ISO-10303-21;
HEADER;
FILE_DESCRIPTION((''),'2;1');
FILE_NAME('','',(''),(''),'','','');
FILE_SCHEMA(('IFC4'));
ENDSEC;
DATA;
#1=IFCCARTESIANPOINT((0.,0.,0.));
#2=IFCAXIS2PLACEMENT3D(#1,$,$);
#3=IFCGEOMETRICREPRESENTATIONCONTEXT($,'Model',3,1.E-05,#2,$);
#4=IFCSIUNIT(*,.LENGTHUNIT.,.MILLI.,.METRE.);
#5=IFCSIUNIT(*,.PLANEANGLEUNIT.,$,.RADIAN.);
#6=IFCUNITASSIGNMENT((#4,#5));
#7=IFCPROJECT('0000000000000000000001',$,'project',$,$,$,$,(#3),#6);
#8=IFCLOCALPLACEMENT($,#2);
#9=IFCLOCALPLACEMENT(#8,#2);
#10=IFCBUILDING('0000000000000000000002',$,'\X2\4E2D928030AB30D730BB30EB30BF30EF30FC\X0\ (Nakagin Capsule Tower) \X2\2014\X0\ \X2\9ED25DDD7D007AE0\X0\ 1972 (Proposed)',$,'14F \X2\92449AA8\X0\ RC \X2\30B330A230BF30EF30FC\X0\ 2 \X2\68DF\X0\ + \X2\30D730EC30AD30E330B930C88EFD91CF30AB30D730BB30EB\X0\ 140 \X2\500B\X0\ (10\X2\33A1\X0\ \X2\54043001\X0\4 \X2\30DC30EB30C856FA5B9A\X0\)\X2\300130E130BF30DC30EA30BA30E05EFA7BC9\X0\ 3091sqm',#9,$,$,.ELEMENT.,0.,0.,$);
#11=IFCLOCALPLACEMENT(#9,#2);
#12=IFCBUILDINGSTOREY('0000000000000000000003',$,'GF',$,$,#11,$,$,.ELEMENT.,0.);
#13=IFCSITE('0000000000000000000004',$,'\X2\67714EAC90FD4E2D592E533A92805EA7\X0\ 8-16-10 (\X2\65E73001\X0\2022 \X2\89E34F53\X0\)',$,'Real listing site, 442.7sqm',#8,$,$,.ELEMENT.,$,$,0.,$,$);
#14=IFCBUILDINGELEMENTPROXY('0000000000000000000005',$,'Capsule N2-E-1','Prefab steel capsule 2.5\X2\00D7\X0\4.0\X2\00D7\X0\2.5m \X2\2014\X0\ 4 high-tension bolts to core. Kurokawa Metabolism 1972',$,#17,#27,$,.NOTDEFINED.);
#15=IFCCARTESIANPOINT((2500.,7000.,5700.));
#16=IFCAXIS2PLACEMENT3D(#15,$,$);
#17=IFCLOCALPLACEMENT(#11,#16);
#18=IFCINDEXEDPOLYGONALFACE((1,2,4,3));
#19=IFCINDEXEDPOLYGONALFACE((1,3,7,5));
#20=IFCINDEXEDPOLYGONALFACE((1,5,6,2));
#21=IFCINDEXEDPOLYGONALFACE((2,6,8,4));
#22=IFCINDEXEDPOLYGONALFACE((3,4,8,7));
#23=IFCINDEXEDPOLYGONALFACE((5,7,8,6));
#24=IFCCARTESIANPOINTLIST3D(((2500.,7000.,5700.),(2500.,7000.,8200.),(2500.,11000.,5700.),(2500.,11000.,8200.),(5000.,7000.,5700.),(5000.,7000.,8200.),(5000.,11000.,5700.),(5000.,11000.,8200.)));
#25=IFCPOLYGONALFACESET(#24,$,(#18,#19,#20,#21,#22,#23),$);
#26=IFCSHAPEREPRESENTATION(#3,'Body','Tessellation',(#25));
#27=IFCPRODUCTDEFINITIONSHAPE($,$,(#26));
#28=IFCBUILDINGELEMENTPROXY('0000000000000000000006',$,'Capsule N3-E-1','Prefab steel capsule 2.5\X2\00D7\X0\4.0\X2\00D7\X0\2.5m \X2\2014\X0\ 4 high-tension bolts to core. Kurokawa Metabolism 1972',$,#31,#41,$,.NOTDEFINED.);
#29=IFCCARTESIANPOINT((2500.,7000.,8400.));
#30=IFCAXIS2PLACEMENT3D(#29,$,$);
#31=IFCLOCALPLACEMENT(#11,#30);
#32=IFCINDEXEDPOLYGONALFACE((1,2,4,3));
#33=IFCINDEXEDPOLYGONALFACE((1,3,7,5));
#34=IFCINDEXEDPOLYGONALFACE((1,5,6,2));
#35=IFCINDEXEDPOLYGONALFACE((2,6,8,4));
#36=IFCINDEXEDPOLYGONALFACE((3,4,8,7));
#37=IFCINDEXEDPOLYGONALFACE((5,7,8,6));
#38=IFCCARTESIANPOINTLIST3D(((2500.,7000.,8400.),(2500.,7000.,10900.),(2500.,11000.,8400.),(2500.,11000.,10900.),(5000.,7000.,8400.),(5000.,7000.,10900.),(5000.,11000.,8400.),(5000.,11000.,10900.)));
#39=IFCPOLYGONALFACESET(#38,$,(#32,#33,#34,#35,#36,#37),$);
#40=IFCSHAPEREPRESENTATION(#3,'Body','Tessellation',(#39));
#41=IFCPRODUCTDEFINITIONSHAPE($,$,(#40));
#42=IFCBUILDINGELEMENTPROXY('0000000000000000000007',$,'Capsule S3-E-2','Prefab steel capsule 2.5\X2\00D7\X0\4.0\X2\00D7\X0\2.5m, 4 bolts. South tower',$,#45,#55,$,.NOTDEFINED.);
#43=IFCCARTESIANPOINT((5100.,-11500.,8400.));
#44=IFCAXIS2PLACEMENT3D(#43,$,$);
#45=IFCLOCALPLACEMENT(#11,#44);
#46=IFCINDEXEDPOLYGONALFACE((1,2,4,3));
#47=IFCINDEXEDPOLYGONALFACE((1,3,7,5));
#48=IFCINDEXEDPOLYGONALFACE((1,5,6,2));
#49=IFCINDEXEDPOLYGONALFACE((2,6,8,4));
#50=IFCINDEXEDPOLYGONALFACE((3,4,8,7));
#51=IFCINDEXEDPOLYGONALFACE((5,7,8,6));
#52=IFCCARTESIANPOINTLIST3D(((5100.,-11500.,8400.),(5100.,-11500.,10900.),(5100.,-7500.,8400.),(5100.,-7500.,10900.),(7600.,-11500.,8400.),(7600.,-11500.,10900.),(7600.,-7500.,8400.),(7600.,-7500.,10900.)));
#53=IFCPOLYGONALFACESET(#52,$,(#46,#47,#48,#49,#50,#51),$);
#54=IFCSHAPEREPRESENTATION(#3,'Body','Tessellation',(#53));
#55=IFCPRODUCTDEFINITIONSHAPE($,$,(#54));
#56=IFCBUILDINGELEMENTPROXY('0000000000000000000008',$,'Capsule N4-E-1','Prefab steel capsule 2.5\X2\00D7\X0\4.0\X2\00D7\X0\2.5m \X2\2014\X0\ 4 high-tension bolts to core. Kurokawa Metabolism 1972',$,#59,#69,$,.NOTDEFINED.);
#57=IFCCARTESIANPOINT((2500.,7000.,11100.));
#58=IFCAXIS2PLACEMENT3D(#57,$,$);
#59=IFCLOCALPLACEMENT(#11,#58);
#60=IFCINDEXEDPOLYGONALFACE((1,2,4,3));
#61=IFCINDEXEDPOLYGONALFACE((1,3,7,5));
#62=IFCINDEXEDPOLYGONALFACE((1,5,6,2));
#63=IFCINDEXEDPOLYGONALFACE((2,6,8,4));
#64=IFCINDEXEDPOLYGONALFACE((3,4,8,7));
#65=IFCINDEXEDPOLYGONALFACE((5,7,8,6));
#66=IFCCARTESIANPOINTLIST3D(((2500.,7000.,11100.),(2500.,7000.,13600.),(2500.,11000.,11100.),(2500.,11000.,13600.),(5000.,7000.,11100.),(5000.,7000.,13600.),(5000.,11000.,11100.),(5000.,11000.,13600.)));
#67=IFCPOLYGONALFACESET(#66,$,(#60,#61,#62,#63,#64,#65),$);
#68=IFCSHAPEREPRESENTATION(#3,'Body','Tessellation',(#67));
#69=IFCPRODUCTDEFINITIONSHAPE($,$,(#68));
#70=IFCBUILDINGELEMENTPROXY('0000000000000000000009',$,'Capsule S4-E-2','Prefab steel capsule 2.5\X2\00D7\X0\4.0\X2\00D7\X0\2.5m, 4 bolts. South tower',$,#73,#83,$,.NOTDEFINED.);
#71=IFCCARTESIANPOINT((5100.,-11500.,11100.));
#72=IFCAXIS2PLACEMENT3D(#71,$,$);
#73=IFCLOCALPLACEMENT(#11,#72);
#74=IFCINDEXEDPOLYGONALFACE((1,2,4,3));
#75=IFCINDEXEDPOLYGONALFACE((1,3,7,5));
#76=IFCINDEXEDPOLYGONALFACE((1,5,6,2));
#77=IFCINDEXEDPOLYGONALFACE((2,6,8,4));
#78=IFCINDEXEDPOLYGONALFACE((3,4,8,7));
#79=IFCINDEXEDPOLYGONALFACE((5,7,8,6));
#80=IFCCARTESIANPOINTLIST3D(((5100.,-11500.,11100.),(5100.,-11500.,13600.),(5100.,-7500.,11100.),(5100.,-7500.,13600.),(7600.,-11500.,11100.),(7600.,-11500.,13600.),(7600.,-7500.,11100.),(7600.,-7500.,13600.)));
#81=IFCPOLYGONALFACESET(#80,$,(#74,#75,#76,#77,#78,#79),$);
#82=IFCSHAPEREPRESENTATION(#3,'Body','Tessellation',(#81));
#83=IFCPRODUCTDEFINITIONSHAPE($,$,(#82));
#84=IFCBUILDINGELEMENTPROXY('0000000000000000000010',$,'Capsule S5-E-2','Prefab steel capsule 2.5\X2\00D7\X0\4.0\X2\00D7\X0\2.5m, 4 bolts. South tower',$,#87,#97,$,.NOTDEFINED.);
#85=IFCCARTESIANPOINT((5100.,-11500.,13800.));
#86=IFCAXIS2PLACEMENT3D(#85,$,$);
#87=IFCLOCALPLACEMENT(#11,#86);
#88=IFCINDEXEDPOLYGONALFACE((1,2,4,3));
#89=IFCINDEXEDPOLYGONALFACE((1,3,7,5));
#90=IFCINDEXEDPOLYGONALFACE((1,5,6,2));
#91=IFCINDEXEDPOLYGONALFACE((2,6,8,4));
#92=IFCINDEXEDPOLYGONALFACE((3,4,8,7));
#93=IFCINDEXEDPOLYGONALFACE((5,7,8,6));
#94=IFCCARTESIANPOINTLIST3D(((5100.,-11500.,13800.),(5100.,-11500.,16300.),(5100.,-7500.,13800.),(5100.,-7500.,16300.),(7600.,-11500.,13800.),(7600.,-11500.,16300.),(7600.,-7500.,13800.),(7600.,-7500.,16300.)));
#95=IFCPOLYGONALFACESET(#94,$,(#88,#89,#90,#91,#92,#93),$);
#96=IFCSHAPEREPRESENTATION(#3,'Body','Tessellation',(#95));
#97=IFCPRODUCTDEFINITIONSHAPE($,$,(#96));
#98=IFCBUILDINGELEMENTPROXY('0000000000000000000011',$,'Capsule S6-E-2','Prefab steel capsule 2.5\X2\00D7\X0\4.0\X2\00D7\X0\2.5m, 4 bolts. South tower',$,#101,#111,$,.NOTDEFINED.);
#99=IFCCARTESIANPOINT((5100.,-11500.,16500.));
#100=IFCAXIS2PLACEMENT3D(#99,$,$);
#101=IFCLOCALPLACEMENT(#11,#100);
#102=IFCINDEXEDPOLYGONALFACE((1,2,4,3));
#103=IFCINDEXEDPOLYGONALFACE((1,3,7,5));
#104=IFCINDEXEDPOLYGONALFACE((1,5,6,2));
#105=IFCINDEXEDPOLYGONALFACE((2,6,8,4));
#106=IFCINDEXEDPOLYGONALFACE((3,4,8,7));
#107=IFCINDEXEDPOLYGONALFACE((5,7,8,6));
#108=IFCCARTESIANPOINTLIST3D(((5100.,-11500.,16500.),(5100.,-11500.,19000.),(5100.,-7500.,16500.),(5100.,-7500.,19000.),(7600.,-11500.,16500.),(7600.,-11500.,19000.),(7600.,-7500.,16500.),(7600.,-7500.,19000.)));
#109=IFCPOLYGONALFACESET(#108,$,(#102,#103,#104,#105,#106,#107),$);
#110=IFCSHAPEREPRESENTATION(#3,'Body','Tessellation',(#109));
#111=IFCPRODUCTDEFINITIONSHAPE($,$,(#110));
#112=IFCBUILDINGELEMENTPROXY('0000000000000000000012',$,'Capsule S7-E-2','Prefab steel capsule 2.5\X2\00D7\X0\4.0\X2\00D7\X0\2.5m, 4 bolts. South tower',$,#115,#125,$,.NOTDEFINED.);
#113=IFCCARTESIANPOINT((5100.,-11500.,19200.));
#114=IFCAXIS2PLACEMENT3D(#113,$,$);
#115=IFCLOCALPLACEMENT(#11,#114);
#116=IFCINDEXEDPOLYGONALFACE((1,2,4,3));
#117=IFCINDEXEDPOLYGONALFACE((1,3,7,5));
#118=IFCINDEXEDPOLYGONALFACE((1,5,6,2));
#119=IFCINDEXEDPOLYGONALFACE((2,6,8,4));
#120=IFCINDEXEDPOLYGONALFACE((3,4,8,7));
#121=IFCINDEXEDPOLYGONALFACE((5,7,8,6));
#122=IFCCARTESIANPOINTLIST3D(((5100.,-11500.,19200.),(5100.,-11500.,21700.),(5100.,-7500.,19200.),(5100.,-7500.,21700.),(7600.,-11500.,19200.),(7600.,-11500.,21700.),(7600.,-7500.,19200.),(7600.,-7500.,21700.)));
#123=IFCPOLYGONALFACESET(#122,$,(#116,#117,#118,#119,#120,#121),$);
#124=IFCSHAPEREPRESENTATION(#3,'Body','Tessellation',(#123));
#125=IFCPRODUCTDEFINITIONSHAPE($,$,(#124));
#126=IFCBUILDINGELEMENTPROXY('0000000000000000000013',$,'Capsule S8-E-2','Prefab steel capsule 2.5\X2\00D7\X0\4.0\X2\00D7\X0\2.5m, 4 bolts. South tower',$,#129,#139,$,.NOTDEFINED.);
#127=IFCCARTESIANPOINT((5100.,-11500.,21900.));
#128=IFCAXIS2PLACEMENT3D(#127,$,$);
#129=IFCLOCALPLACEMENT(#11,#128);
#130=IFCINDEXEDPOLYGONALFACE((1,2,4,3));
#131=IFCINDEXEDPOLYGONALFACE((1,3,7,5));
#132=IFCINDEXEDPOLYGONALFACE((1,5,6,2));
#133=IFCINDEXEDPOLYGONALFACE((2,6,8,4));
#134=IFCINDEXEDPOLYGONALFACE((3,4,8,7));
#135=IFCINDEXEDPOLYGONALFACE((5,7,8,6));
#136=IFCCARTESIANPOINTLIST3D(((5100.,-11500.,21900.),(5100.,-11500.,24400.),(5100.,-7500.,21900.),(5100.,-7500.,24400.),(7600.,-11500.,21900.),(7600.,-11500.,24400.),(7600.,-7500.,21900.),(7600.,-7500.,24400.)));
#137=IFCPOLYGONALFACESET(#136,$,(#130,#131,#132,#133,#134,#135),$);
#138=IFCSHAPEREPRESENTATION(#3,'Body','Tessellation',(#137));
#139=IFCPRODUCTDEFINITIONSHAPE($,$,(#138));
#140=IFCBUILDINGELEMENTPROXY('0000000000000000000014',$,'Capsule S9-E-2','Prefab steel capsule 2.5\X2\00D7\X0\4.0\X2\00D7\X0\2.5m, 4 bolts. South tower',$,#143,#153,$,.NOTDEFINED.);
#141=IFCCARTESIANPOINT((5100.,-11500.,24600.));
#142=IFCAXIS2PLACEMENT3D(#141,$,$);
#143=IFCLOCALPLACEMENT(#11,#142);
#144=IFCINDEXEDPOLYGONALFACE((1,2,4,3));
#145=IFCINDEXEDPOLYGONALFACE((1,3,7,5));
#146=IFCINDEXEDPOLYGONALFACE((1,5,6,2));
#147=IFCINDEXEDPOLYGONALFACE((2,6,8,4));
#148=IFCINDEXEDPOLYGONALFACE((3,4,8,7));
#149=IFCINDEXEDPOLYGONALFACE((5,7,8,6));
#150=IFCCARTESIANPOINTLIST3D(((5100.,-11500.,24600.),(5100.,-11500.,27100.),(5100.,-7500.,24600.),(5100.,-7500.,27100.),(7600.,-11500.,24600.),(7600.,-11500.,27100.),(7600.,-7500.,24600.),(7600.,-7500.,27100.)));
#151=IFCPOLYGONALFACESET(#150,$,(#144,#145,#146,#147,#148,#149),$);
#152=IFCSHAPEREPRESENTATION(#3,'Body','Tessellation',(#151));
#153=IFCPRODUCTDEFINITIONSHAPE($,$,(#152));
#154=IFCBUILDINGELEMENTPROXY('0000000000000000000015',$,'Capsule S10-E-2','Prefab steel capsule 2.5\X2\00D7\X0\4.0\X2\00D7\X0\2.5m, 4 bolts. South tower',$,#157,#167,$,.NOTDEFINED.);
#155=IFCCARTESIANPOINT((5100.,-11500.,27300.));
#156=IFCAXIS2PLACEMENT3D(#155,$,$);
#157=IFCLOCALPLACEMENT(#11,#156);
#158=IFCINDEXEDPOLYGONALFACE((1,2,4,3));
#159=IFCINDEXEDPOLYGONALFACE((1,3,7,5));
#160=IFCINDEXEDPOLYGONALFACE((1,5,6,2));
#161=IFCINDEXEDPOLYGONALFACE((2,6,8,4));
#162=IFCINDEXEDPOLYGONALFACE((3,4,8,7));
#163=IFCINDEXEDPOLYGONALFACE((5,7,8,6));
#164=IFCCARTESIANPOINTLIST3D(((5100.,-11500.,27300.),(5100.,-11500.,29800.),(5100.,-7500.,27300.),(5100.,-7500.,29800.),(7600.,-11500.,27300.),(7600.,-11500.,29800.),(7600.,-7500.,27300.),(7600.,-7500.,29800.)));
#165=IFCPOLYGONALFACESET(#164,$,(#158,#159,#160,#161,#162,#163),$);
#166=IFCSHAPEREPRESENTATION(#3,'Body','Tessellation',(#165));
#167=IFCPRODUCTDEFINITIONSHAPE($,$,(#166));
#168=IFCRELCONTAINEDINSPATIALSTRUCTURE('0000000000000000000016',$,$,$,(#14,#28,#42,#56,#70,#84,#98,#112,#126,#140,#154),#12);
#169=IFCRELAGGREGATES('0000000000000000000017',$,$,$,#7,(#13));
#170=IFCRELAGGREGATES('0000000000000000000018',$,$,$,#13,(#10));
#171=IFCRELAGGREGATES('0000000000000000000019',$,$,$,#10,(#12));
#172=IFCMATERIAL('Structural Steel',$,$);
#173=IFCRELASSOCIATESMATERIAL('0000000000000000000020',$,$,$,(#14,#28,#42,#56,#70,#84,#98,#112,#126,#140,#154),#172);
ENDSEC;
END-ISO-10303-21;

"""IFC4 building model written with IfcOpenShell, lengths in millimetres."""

from ifc_helpers import new_model, si_unit, frame, frame_2d, origin, place, context, project, spatial, rectangle, extrude, material, element, save


model = new_model("IFC4")

# Units and contexts
model_context = context("Model", 3, precision=1e-05, world=origin())
ifc_project = project(units=[si_unit("LENGTHUNIT", "METRE", prefix="MILLI"), si_unit("PLANEANGLEUNIT", "RADIAN")], contexts=[model_context])

# Site, building, storey
site_placement = place(None, origin())
site = spatial("IfcSite", under=ifc_project, at=site_placement, Name="東京都中央区銀座 8-16-10 (旧、2022 解体)", ObjectType="Real listing site, 442.7sqm", CompositionType="ELEMENT", RefElevation=0.0)
building_placement = place(site_placement, origin())
building = spatial("IfcBuilding", under=site, at=building_placement, Name="中銀カプセルタワー (Nakagin Capsule Tower) — 黒川紀章 1972 (Proposed)", ObjectType="14F 鉄骨 RC コアタワー 2 棟 + プレキャスト軽量カプセル 140 個 (10㎡ 各、4 ボルト固定)、メタボリズム建築 3091sqm", CompositionType="ELEMENT", ElevationOfRefHeight=0.0, ElevationOfTerrain=0.0)
storey_placement = place(building_placement, origin())
storey = spatial("IfcBuildingStorey", under=building, at=storey_placement, Name="GF", CompositionType="ELEMENT", Elevation=0.0)

# Shared definitions
ifc_material_1 = material(Name="Structural Steel")

# Building element proxies
proxy_1_placement = place(storey_placement, frame((2500.0, 7000.0, 5700.0)))
element("IfcBuildingElementProxy", 1, at=proxy_1_placement, inside=storey, material=ifc_material_1, Name="Capsule N2-E-1", Description="Prefab steel capsule 2.5×4.0×2.5m — 4 high-tension bolts to core. Kurokawa Metabolism 1972", PredefinedType="NOTDEFINED", context=model_context, shape_type="SweptSolid", body=[
    extrude(rectangle(XDim=2500.0, YDim=4000.0, at=frame_2d((1250.0, 2000.0))), frame((2500.0, 7000.0, 5700.0)), (0.0, 0.0, 1.0), 2500.0),
])
proxy_2_placement = place(storey_placement, frame((2500.0, 7000.0, 8400.0)))
element("IfcBuildingElementProxy", 2, at=proxy_2_placement, inside=storey, material=ifc_material_1, Name="Capsule N3-E-1", Description="Prefab steel capsule 2.5×4.0×2.5m — 4 high-tension bolts to core. Kurokawa Metabolism 1972", PredefinedType="NOTDEFINED", context=model_context, shape_type="SweptSolid", body=[
    extrude(rectangle(XDim=2500.0, YDim=4000.0, at=frame_2d((1250.0, 2000.0))), frame((2500.0, 7000.0, 8400.0)), (0.0, 0.0, 1.0), 2500.0),
])
proxy_3_placement = place(storey_placement, frame((5100.0, -11500.0, 8400.0)))
element("IfcBuildingElementProxy", 3, at=proxy_3_placement, inside=storey, material=ifc_material_1, Name="Capsule S3-E-2", Description="Prefab steel capsule 2.5×4.0×2.5m, 4 bolts. South tower", PredefinedType="NOTDEFINED", context=model_context, shape_type="SweptSolid", body=[
    extrude(rectangle(XDim=2500.0, YDim=4000.0, at=frame_2d((1250.0, 2000.0))), frame((5100.0, -11500.0, 8400.0)), (0.0, 0.0, 1.0), 2500.0),
])
proxy_4_placement = place(storey_placement, frame((2500.0, 7000.0, 11100.0)))
element("IfcBuildingElementProxy", 4, at=proxy_4_placement, inside=storey, material=ifc_material_1, Name="Capsule N4-E-1", Description="Prefab steel capsule 2.5×4.0×2.5m — 4 high-tension bolts to core. Kurokawa Metabolism 1972", PredefinedType="NOTDEFINED", context=model_context, shape_type="SweptSolid", body=[
    extrude(rectangle(XDim=2500.0, YDim=4000.0, at=frame_2d((1250.0, 2000.0))), frame((2500.0, 7000.0, 11100.0)), (0.0, 0.0, 1.0), 2500.0),
])
proxy_5_placement = place(storey_placement, frame((5100.0, -11500.0, 11100.0)))
element("IfcBuildingElementProxy", 5, at=proxy_5_placement, inside=storey, material=ifc_material_1, Name="Capsule S4-E-2", Description="Prefab steel capsule 2.5×4.0×2.5m, 4 bolts. South tower", PredefinedType="NOTDEFINED", context=model_context, shape_type="SweptSolid", body=[
    extrude(rectangle(XDim=2500.0, YDim=4000.0, at=frame_2d((1250.0, 2000.0))), frame((5100.0, -11500.0, 11100.0)), (0.0, 0.0, 1.0), 2500.0),
])
proxy_6_placement = place(storey_placement, frame((5100.0, -11500.0, 13800.0)))
element("IfcBuildingElementProxy", 6, at=proxy_6_placement, inside=storey, material=ifc_material_1, Name="Capsule S5-E-2", Description="Prefab steel capsule 2.5×4.0×2.5m, 4 bolts. South tower", PredefinedType="NOTDEFINED", context=model_context, shape_type="SweptSolid", body=[
    extrude(rectangle(XDim=2500.0, YDim=4000.0, at=frame_2d((1250.0, 2000.0))), frame((5100.0, -11500.0, 13800.0)), (0.0, 0.0, 1.0), 2500.0),
])
proxy_7_placement = place(storey_placement, frame((5100.0, -11500.0, 16500.0)))
element("IfcBuildingElementProxy", 7, at=proxy_7_placement, inside=storey, material=ifc_material_1, Name="Capsule S6-E-2", Description="Prefab steel capsule 2.5×4.0×2.5m, 4 bolts. South tower", PredefinedType="NOTDEFINED", context=model_context, shape_type="SweptSolid", body=[
    extrude(rectangle(XDim=2500.0, YDim=4000.0, at=frame_2d((1250.0, 2000.0))), frame((5100.0, -11500.0, 16500.0)), (0.0, 0.0, 1.0), 2500.0),
])
proxy_8_placement = place(storey_placement, frame((5100.0, -11500.0, 19200.0)))
element("IfcBuildingElementProxy", 8, at=proxy_8_placement, inside=storey, material=ifc_material_1, Name="Capsule S7-E-2", Description="Prefab steel capsule 2.5×4.0×2.5m, 4 bolts. South tower", PredefinedType="NOTDEFINED", context=model_context, shape_type="SweptSolid", body=[
    extrude(rectangle(XDim=2500.0, YDim=4000.0, at=frame_2d((1250.0, 2000.0))), frame((5100.0, -11500.0, 19200.0)), (0.0, 0.0, 1.0), 2500.0),
])
proxy_9_placement = place(storey_placement, frame((5100.0, -11500.0, 21900.0)))
element("IfcBuildingElementProxy", 9, at=proxy_9_placement, inside=storey, material=ifc_material_1, Name="Capsule S8-E-2", Description="Prefab steel capsule 2.5×4.0×2.5m, 4 bolts. South tower", PredefinedType="NOTDEFINED", context=model_context, shape_type="SweptSolid", body=[
    extrude(rectangle(XDim=2500.0, YDim=4000.0, at=frame_2d((1250.0, 2000.0))), frame((5100.0, -11500.0, 21900.0)), (0.0, 0.0, 1.0), 2500.0),
])
proxy_10_placement = place(storey_placement, frame((5100.0, -11500.0, 24600.0)))
element("IfcBuildingElementProxy", 10, at=proxy_10_placement, inside=storey, material=ifc_material_1, Name="Capsule S9-E-2", Description="Prefab steel capsule 2.5×4.0×2.5m, 4 bolts. South tower", PredefinedType="NOTDEFINED", context=model_context, shape_type="SweptSolid", body=[
    extrude(rectangle(XDim=2500.0, YDim=4000.0, at=frame_2d((1250.0, 2000.0))), frame((5100.0, -11500.0, 24600.0)), (0.0, 0.0, 1.0), 2500.0),
])
proxy_11_placement = place(storey_placement, frame((5100.0, -11500.0, 27300.0)))
element("IfcBuildingElementProxy", 11, at=proxy_11_placement, inside=storey, material=ifc_material_1, Name="Capsule S10-E-2", Description="Prefab steel capsule 2.5×4.0×2.5m, 4 bolts. South tower", PredefinedType="NOTDEFINED", context=model_context, shape_type="SweptSolid", body=[
    extrude(rectangle(XDim=2500.0, YDim=4000.0, at=frame_2d((1250.0, 2000.0))), frame((5100.0, -11500.0, 27300.0)), (0.0, 0.0, 1.0), 2500.0),
])

save(model, "model.ifc")
